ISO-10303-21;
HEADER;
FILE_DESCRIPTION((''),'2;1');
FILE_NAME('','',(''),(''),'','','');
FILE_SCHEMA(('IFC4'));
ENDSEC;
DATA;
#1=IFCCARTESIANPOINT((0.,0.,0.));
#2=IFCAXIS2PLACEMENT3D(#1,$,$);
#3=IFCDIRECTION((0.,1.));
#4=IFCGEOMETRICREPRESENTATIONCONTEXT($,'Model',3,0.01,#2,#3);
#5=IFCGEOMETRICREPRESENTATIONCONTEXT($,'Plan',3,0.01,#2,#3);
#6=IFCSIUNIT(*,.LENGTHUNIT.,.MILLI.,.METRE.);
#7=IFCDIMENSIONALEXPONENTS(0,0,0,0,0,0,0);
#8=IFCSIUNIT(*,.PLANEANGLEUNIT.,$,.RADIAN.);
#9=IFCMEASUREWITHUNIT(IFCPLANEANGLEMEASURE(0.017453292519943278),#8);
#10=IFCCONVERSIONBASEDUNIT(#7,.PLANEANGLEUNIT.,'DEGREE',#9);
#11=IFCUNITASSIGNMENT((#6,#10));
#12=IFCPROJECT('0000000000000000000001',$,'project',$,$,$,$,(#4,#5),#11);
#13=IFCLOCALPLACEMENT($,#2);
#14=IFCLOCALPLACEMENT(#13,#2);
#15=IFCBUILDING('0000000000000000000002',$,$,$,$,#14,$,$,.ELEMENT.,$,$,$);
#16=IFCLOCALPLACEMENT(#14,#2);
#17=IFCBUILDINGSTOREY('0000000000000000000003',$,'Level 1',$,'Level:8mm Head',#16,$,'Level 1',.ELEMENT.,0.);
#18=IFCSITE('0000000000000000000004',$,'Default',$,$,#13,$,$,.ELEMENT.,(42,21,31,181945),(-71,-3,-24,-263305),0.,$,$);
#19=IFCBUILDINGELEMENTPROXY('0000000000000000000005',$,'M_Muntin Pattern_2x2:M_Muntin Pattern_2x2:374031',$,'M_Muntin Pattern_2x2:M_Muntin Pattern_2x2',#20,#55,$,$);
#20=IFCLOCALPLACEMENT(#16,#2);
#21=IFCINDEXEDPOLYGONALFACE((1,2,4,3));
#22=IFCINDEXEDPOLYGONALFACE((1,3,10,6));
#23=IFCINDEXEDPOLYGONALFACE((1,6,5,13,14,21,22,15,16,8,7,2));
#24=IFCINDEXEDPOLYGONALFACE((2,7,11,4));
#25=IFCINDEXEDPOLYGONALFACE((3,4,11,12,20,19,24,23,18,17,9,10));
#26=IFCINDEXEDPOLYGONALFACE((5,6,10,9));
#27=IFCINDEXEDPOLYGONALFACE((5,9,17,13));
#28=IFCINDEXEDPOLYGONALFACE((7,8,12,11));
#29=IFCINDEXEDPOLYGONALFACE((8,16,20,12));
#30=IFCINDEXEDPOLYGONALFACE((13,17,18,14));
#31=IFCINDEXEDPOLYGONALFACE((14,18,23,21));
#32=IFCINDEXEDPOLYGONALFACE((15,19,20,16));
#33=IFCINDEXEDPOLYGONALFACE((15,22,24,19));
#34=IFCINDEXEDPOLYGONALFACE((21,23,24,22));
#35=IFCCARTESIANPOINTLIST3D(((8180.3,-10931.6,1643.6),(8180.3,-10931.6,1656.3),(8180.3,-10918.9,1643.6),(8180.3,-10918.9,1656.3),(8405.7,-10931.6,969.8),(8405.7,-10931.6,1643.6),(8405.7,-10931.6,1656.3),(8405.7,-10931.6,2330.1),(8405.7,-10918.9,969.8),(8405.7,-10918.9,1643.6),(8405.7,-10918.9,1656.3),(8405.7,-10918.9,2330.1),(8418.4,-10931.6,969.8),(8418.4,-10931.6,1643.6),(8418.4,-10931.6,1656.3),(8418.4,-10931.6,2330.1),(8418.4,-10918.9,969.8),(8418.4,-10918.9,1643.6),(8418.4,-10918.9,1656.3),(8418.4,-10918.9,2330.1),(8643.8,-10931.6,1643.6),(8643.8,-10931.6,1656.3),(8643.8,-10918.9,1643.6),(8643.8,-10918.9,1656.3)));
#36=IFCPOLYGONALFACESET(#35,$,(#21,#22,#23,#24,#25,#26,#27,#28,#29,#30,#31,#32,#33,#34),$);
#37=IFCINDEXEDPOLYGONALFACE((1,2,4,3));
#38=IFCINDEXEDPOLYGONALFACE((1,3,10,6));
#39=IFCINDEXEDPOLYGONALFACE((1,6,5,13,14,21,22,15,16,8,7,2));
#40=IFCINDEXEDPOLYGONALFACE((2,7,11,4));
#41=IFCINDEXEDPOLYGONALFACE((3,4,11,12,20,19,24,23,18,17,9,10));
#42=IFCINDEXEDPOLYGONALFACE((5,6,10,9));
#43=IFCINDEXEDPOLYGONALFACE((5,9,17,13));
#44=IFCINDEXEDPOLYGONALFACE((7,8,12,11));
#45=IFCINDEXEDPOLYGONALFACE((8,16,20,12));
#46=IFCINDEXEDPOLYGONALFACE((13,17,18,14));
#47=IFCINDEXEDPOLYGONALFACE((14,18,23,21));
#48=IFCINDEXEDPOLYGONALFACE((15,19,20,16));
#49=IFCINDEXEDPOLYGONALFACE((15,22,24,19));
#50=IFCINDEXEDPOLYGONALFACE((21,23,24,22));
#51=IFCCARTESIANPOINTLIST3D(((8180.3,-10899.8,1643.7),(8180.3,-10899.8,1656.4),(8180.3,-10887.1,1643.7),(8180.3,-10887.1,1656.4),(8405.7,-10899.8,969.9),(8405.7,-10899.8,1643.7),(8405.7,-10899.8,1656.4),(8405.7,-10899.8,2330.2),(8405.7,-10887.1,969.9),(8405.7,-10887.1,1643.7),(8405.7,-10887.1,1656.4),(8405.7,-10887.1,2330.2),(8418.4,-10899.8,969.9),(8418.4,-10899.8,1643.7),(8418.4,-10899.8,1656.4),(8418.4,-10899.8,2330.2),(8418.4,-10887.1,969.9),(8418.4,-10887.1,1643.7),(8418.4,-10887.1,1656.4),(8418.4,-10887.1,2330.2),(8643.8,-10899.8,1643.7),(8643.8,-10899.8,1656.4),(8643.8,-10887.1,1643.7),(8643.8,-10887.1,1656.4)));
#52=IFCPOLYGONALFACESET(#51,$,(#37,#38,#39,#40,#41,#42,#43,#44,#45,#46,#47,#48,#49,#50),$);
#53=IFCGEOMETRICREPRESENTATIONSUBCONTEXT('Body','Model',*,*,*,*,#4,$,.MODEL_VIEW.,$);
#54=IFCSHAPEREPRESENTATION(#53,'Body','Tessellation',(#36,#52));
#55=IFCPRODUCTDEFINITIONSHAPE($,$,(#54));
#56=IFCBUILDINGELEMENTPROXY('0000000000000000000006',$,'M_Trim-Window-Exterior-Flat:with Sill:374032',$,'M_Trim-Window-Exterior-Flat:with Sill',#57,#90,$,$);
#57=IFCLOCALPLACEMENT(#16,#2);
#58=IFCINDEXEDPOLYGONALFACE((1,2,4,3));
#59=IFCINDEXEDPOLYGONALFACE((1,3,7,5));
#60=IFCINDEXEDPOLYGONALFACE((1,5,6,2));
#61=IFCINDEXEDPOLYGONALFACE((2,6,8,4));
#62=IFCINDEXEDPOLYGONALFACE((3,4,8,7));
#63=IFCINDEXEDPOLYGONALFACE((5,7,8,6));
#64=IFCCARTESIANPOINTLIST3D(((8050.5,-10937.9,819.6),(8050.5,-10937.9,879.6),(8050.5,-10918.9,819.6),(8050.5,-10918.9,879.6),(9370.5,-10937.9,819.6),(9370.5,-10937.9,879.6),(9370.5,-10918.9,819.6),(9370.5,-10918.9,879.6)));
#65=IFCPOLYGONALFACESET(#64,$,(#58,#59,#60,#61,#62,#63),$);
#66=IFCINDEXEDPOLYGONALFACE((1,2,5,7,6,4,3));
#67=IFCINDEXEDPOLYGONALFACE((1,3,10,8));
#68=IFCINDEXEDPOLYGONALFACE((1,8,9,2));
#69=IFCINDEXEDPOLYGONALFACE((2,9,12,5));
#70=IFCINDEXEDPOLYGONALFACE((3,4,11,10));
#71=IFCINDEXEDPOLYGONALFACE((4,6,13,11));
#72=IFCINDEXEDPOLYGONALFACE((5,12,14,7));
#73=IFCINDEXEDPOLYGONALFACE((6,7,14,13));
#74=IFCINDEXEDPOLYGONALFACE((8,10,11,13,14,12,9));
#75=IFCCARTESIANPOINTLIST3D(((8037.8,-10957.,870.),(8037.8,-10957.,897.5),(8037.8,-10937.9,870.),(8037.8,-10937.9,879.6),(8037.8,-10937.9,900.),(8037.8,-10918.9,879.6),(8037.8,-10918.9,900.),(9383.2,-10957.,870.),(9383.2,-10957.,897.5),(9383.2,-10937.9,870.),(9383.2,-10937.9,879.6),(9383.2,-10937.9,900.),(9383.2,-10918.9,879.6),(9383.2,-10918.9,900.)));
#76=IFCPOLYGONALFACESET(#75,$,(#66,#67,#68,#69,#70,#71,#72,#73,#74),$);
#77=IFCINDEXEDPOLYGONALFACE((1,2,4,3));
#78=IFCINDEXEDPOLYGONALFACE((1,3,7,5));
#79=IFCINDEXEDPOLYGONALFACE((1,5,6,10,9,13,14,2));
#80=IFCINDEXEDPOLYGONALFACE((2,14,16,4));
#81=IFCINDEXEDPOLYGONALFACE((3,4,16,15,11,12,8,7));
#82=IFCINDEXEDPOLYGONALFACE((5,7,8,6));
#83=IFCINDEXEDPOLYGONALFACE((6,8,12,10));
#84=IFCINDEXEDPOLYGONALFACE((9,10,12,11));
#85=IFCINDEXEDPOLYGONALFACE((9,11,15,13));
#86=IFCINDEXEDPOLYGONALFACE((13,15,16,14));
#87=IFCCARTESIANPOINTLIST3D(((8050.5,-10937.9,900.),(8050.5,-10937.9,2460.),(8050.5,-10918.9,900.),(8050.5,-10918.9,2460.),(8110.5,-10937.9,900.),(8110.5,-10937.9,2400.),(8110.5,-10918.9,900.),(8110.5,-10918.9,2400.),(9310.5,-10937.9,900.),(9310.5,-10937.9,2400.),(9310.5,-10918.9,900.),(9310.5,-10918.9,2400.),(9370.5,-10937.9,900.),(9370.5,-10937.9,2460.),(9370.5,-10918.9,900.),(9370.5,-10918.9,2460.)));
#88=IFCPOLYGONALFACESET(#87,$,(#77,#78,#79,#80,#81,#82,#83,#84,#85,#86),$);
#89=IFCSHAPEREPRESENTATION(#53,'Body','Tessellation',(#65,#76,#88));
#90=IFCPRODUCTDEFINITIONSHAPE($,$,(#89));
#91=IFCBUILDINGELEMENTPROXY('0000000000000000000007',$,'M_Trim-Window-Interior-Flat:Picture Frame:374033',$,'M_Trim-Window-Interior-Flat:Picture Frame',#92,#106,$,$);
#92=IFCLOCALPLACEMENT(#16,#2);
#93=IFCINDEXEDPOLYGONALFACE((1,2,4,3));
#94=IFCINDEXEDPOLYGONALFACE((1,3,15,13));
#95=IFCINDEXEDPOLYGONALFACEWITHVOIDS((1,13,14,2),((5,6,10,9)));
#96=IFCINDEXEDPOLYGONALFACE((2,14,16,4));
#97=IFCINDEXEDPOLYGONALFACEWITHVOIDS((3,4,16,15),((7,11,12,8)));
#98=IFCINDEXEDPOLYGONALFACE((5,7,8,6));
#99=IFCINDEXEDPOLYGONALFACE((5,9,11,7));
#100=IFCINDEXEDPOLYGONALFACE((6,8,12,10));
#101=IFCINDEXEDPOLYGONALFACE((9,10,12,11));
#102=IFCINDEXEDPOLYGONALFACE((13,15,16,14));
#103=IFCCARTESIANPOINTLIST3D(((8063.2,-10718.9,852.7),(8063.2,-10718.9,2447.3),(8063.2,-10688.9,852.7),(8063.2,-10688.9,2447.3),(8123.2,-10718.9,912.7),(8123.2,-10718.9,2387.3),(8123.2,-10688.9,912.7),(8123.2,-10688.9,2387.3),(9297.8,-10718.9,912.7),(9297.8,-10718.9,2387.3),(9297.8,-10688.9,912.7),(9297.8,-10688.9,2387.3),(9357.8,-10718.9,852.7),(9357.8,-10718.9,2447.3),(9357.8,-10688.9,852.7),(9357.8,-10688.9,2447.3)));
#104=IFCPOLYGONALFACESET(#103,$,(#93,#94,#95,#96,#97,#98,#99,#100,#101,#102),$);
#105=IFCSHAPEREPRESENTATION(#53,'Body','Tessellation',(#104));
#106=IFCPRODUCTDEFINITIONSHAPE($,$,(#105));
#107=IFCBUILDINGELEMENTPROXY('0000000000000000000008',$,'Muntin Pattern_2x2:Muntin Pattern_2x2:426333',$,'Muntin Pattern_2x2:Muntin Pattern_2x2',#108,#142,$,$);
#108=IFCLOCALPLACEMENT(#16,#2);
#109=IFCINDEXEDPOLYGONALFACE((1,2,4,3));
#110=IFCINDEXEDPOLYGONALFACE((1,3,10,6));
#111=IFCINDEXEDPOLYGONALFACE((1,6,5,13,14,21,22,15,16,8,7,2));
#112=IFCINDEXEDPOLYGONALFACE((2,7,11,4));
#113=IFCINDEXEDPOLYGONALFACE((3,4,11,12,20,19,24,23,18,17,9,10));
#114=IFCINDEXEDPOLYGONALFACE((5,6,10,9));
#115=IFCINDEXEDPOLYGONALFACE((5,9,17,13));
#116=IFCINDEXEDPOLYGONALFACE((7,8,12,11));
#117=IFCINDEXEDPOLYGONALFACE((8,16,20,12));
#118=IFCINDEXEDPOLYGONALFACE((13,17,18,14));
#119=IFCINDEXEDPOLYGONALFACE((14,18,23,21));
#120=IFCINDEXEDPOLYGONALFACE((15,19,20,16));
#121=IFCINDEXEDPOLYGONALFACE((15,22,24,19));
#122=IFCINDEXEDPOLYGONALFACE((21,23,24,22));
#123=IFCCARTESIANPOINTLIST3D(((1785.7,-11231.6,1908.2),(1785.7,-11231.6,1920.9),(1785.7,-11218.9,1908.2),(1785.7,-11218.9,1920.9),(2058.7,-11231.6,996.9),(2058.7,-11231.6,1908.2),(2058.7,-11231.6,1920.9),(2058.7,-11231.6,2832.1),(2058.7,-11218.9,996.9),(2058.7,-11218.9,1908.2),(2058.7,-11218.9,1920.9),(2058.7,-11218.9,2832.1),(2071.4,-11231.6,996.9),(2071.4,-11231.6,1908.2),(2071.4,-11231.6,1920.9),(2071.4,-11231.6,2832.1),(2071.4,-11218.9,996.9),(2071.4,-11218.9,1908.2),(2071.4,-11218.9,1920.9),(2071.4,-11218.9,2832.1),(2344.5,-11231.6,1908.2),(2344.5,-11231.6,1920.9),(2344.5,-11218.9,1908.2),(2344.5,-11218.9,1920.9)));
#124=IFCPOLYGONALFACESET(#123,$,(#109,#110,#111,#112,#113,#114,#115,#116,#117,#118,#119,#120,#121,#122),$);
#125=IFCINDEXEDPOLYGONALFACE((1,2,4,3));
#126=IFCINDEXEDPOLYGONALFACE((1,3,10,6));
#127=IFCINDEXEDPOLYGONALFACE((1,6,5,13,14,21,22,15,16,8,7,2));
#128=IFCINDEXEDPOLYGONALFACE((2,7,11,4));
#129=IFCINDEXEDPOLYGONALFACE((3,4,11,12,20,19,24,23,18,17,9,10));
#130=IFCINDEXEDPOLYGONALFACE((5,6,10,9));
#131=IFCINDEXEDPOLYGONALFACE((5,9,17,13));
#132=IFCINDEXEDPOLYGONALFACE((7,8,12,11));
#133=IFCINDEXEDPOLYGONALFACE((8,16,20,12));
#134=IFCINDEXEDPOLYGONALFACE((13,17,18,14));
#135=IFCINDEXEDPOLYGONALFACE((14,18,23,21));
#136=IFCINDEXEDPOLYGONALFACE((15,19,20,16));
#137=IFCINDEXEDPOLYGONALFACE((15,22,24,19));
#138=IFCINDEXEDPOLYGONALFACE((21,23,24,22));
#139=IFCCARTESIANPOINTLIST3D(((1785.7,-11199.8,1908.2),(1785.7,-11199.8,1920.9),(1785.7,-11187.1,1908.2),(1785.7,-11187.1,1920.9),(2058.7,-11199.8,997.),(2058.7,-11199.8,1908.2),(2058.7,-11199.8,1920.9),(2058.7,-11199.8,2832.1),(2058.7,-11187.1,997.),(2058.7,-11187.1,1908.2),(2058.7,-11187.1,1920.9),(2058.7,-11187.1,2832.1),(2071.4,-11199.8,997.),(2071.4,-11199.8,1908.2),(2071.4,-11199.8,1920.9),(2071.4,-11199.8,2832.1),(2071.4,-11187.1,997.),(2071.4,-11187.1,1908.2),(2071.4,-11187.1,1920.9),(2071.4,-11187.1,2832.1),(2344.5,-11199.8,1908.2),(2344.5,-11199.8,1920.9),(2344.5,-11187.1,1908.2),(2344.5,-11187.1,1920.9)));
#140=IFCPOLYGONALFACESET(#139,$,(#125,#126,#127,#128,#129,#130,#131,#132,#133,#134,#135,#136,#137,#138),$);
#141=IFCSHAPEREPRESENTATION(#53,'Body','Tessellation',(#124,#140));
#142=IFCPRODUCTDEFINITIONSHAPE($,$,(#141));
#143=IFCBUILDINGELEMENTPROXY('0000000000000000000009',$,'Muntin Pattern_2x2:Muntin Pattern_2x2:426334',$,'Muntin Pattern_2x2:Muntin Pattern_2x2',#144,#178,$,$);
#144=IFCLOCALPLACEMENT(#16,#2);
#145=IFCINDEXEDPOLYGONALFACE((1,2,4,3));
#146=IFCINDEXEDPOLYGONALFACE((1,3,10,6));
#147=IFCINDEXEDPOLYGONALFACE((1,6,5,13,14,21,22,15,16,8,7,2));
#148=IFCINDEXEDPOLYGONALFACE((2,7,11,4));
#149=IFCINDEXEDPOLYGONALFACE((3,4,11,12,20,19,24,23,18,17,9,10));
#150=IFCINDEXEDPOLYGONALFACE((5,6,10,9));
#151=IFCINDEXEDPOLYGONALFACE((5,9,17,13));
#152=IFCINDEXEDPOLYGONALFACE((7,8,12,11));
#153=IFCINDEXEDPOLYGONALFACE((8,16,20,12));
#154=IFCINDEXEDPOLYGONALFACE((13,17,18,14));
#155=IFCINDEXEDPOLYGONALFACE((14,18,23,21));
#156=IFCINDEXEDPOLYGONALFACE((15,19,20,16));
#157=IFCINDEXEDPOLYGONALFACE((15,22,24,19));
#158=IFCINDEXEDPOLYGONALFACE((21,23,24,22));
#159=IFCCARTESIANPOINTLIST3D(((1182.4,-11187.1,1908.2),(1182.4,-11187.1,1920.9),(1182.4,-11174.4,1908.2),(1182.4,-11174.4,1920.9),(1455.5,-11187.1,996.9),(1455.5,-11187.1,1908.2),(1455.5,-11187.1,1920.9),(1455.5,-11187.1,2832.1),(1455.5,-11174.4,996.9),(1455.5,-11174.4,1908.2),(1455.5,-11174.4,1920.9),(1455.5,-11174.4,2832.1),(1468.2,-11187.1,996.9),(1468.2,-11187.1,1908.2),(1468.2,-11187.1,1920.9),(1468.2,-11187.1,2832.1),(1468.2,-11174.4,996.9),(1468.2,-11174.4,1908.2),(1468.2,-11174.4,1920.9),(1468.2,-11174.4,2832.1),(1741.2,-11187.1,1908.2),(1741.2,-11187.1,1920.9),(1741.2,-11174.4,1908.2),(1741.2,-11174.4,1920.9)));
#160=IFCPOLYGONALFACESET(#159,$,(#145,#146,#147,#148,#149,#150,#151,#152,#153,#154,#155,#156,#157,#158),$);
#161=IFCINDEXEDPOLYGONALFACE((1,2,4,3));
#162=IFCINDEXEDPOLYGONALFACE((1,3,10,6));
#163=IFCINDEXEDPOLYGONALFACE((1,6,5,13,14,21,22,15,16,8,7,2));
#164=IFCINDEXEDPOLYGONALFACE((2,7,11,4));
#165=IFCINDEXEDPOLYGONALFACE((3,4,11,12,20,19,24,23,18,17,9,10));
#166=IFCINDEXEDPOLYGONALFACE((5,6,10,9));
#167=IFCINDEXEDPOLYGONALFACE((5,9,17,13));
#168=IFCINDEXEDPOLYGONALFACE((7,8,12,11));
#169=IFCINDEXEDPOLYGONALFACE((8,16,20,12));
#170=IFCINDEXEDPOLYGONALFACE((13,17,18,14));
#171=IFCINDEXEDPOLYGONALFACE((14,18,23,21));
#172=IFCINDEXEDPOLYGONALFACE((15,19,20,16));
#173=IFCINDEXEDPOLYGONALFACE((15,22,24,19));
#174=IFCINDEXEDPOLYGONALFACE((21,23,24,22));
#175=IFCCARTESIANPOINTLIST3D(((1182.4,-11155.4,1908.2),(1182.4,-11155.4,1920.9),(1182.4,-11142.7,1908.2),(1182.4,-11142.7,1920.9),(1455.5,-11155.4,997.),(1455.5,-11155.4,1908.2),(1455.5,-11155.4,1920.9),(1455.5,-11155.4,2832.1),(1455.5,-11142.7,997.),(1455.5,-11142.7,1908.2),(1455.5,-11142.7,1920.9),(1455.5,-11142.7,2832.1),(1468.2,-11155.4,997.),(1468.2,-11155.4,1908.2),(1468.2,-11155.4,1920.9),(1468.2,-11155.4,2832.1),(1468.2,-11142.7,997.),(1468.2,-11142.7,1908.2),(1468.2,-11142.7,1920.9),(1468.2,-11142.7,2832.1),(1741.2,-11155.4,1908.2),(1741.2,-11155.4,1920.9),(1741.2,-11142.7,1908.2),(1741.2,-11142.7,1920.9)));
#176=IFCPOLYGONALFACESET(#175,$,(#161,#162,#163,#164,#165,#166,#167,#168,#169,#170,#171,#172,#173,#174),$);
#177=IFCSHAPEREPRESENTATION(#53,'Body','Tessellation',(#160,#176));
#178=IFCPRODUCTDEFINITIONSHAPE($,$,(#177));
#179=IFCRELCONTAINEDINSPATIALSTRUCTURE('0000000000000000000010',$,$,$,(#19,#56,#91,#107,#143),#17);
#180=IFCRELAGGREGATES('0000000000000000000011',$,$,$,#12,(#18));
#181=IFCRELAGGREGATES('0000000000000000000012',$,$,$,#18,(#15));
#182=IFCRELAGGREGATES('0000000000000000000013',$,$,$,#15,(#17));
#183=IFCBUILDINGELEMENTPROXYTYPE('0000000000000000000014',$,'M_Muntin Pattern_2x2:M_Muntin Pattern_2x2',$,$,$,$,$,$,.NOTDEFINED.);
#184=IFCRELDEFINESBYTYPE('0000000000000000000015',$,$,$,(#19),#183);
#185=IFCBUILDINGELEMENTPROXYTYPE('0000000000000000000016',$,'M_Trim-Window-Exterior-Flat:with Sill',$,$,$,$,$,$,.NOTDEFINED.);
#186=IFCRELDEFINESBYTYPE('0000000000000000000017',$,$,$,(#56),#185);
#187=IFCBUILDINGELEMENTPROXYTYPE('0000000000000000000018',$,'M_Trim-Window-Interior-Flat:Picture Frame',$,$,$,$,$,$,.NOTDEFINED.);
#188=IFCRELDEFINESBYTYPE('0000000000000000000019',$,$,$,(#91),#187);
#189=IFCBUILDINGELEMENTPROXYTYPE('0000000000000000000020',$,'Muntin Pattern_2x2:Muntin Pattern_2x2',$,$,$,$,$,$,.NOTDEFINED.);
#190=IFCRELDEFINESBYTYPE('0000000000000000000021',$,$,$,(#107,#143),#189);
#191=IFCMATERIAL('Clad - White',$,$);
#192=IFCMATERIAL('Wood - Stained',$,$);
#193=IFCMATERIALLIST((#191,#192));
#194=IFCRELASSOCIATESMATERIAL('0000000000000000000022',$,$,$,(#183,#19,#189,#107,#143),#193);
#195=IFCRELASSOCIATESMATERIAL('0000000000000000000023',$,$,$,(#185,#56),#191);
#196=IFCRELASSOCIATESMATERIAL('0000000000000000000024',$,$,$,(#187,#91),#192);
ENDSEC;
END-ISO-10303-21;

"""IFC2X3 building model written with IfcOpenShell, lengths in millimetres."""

from ifc_helpers import new_model, entity, si_unit, converted_unit, direction, frame, frame_2d, origin, place, context, subcontext, project, spatial, polyline, rectangle, outline, extrude, source, transform, mapped, material, material_list, type_object, type_shapes, element, save


model = new_model("IFC2X3")

# Units and contexts
model_context = context("Model", 3, precision=0.01, world=origin(), true_north=direction((0.0, 1.0)))
plan_context = context("Plan", 3, precision=0.01, world=origin(), true_north=direction((0.0, 1.0)))
body_context = subcontext(model_context, "Body", "Model", "MODEL_VIEW")
ifc_project = project(units=[si_unit("LENGTHUNIT", "METRE", prefix="MILLI"), converted_unit("PLANEANGLEUNIT", "DEGREE", entity("IfcPlaneAngleMeasure", 0.017453292519943278), si_unit("PLANEANGLEUNIT", "RADIAN"), dimensions=[0, 0, 0, 0, 0, 0, 0])], contexts=[model_context, plan_context])

# Site, building, storey
site_placement = place(None, origin())
site = spatial("IfcSite", under=ifc_project, at=site_placement, Name="Default", CompositionType="ELEMENT", RefLatitude=(42, 21, 31, 181945), RefLongitude=(-71, -3, -24, -263305), RefElevation=0.0)
building_placement = place(site_placement, origin())
building = spatial("IfcBuilding", under=site, at=building_placement, CompositionType="ELEMENT")
storey_placement = place(building_placement, origin())
storey = spatial("IfcBuildingStorey", under=building, at=storey_placement, Name="Level 1", ObjectType="Level:8mm Head", LongName="Level 1", CompositionType="ELEMENT", Elevation=0.0)

# Building element proxies
ifc_material_1 = material(Name="Clad - White")
ifc_material_2 = material(Name="Wood - Stained")
ifc_material_list_1 = material_list([ifc_material_1, ifc_material_2])
building_element_proxy_type_1 = type_object("IfcBuildingElementProxyType", Name="M_Muntin Pattern_2x2:M_Muntin Pattern_2x2", PredefinedType="NOTDEFINED", material=ifc_material_list_1)
shared_shape_1 = source(origin(), body_context, "Body", "SweptSolid", [
    extrude(outline(polyline([(6.4, -6.4), (680.1, -6.4), (680.1, 6.3), (6.4, 6.3), (6.4, 231.7), (-6.3, 231.7), (-6.3, 6.3), (-680.2, 6.3), (-680.2, -6.4), (-6.3, -6.4), (-6.3, -231.7), (6.4, -231.7), (6.4, -6.4)])), frame((0.0, -22.2, 680.1), z_axis=(0.0, 1.0, 0.0), x_axis=(0.0, 0.0, 1.0)), (0.0, 0.0, 1.0), 12.7),
    extrude(outline(polyline([(6.4, -6.4), (680.2, -6.4), (680.2, 6.3), (6.4, 6.3), (6.4, 231.7), (-6.3, 231.7), (-6.3, 6.3), (-680.2, 6.3), (-680.2, -6.4), (-6.3, -6.4), (-6.3, -231.7), (6.4, -231.7), (6.4, -6.4)])), frame((0.0, 9.5, 680.2), z_axis=(0.0, 1.0, 0.0), x_axis=(0.0, 0.0, 1.0)), (0.0, 0.0, 1.0), 12.7),
])
type_shapes(building_element_proxy_type_1, [shared_shape_1])
proxy_1_placement = place(storey_placement, frame((8412.1, -10909.4, 969.9)))
element("IfcBuildingElementProxy", 1, at=proxy_1_placement, inside=storey, type_object=building_element_proxy_type_1, material=ifc_material_list_1, Name="M_Muntin Pattern_2x2:M_Muntin Pattern_2x2:374031", ObjectType="M_Muntin Pattern_2x2:M_Muntin Pattern_2x2", context=body_context, shape_type="MappedRepresentation", body=[
    mapped(shared_shape_1, transform((0.0, 0.0, 0.0), scale=1.0)),
])
building_element_proxy_type_2 = type_object("IfcBuildingElementProxyType", Name="M_Trim-Window-Exterior-Flat:with Sill", PredefinedType="NOTDEFINED", material=ifc_material_1)
shared_shape_2 = source(origin(), body_context, "Body", "SweptSolid", [
    extrude(rectangle(XDim=1320.0, YDim=60.0, at=frame_2d((0.0, 0.0), x_axis=(1.0, 0.0))), frame((0.0, -1550.4, 0.0), z_axis=(0.0, 0.0, 1.0), x_axis=(-1.0, 0.0, 0.0)), (0.0, 0.0, 1.0), 19.0),
    extrude(outline(polyline([(-19.0, -15.2), (0.0, -15.2), (0.0, -5.7), (19.0, -5.7), (19.0, 14.8), (0.0, 14.8), (-19.0, 12.3), (-19.0, -15.2)])), frame((-672.7, -1514.8, 19.0), z_axis=(1.0, 0.0, 0.0), x_axis=(0.0, 0.0, -1.0)), (0.0, 0.0, 1.0), 1345.4),
    extrude(outline(polyline([(-795.0, -660.0), (765.0, -660.0), (765.0, -600.0), (-735.0, -600.0), (-735.0, 600.0), (765.0, 600.0), (765.0, 660.0), (-795.0, 660.0), (-795.0, -660.0)])), frame((0.0, -735.0, 0.0), z_axis=(0.0, 0.0, 1.0), x_axis=(0.0, -1.0, 0.0)), (0.0, 0.0, 1.0), 19.0),
])
type_shapes(building_element_proxy_type_2, [shared_shape_2])
proxy_2_placement = place(storey_placement, frame((8710.5, -10918.9, 2400.0), z_axis=(0.0, -1.0, 0.0), x_axis=(1.0, 0.0, 0.0)))
element("IfcBuildingElementProxy", 2, at=proxy_2_placement, inside=storey, type_object=building_element_proxy_type_2, material=ifc_material_1, Name="M_Trim-Window-Exterior-Flat:with Sill:374032", ObjectType="M_Trim-Window-Exterior-Flat:with Sill", context=body_context, shape_type="MappedRepresentation", body=[
    mapped(shared_shape_2, transform((0.0, 0.0, 0.0), scale=1.0)),
])
building_element_proxy_type_3 = type_object("IfcBuildingElementProxyType", Name="M_Trim-Window-Interior-Flat:Picture Frame", PredefinedType="NOTDEFINED", material=ifc_material_2)
shared_shape_3 = source(origin(), body_context, "Body", "SweptSolid", [
    extrude(outline(polyline([(-647.3, -797.3), (647.3, -797.3), (647.3, 797.3), (-647.3, 797.3), (-647.3, -797.3)]), holes=[polyline([(-587.3, -737.3), (-587.3, 737.3), (587.3, 737.3), (587.3, -737.3), (-587.3, -737.3)])]), frame((0.0, -750.0, 0.0), z_axis=(0.0, 0.0, 1.0), x_axis=(-1.0, 0.0, 0.0)), (0.0, 0.0, 1.0), 30.0),
])
type_shapes(building_element_proxy_type_3, [shared_shape_3])
proxy_3_placement = place(storey_placement, frame((8710.5, -10718.9, 2400.0), z_axis=(0.0, 1.0, 0.0), x_axis=(-1.0, 0.0, 0.0)))
element("IfcBuildingElementProxy", 3, at=proxy_3_placement, inside=storey, type_object=building_element_proxy_type_3, material=ifc_material_2, Name="M_Trim-Window-Interior-Flat:Picture Frame:374033", ObjectType="M_Trim-Window-Interior-Flat:Picture Frame", context=body_context, shape_type="MappedRepresentation", body=[
    mapped(shared_shape_3, transform((0.0, 0.0, 0.0), scale=1.0)),
])
building_element_proxy_type_4 = type_object("IfcBuildingElementProxyType", Name="Muntin Pattern_2x2:Muntin Pattern_2x2", PredefinedType="NOTDEFINED", material=ifc_material_list_1)
shared_shape_4 = source(origin(), body_context, "Body", "SweptSolid", [
    extrude(outline(polyline([(6.4, -6.4), (917.6, -6.4), (917.6, 6.3), (6.4, 6.3), (6.4, 279.4), (-6.3, 279.4), (-6.3, 6.3), (-917.6, 6.3), (-917.6, -6.4), (-6.3, -6.4), (-6.3, -279.4), (6.4, -279.4), (6.4, -6.4)])), frame((0.0, 9.5, 917.6), z_axis=(0.0, 1.0, 0.0), x_axis=(0.0, 0.0, 1.0)), (0.0, 0.0, 1.0), 12.7),
    extrude(outline(polyline([(6.4, -6.4), (917.6, -6.4), (917.6, 6.3), (6.4, 6.3), (6.4, 279.4), (-6.3, 279.4), (-6.3, 6.3), (-917.6, 6.3), (-917.6, -6.4), (-6.3, -6.4), (-6.3, -279.4), (6.4, -279.4), (6.4, -6.4)])), frame((0.0, -22.2, 917.6), z_axis=(0.0, 1.0, 0.0), x_axis=(0.0, 0.0, 1.0)), (0.0, 0.0, 1.0), 12.7),
])
type_shapes(building_element_proxy_type_4, [shared_shape_4])
for number, where, z_axis, x_axis, name in (
    (4, (2065.1, -11209.4, 997.0), (0.0, 0.0, 1.0), (-1.0, 0.0, 0.0), "Muntin Pattern_2x2:Muntin Pattern_2x2:426333"),
    (5, (1461.8, -11164.9, 997.0), (0.0, 0.0, 1.0), (-1.0, 0.0, 0.0), "Muntin Pattern_2x2:Muntin Pattern_2x2:426334"),
):
    element("IfcBuildingElementProxy", number, at=place(storey_placement, frame(where, z_axis=z_axis, x_axis=x_axis)), inside=storey, type_object=building_element_proxy_type_4, material=ifc_material_list_1, Name=name, ObjectType="Muntin Pattern_2x2:Muntin Pattern_2x2", context=body_context, shape_type="MappedRepresentation", body=[
        mapped(shared_shape_4, transform((0.0, 0.0, 0.0), scale=1.0)),
    ])

save(model, "model.ifc")
